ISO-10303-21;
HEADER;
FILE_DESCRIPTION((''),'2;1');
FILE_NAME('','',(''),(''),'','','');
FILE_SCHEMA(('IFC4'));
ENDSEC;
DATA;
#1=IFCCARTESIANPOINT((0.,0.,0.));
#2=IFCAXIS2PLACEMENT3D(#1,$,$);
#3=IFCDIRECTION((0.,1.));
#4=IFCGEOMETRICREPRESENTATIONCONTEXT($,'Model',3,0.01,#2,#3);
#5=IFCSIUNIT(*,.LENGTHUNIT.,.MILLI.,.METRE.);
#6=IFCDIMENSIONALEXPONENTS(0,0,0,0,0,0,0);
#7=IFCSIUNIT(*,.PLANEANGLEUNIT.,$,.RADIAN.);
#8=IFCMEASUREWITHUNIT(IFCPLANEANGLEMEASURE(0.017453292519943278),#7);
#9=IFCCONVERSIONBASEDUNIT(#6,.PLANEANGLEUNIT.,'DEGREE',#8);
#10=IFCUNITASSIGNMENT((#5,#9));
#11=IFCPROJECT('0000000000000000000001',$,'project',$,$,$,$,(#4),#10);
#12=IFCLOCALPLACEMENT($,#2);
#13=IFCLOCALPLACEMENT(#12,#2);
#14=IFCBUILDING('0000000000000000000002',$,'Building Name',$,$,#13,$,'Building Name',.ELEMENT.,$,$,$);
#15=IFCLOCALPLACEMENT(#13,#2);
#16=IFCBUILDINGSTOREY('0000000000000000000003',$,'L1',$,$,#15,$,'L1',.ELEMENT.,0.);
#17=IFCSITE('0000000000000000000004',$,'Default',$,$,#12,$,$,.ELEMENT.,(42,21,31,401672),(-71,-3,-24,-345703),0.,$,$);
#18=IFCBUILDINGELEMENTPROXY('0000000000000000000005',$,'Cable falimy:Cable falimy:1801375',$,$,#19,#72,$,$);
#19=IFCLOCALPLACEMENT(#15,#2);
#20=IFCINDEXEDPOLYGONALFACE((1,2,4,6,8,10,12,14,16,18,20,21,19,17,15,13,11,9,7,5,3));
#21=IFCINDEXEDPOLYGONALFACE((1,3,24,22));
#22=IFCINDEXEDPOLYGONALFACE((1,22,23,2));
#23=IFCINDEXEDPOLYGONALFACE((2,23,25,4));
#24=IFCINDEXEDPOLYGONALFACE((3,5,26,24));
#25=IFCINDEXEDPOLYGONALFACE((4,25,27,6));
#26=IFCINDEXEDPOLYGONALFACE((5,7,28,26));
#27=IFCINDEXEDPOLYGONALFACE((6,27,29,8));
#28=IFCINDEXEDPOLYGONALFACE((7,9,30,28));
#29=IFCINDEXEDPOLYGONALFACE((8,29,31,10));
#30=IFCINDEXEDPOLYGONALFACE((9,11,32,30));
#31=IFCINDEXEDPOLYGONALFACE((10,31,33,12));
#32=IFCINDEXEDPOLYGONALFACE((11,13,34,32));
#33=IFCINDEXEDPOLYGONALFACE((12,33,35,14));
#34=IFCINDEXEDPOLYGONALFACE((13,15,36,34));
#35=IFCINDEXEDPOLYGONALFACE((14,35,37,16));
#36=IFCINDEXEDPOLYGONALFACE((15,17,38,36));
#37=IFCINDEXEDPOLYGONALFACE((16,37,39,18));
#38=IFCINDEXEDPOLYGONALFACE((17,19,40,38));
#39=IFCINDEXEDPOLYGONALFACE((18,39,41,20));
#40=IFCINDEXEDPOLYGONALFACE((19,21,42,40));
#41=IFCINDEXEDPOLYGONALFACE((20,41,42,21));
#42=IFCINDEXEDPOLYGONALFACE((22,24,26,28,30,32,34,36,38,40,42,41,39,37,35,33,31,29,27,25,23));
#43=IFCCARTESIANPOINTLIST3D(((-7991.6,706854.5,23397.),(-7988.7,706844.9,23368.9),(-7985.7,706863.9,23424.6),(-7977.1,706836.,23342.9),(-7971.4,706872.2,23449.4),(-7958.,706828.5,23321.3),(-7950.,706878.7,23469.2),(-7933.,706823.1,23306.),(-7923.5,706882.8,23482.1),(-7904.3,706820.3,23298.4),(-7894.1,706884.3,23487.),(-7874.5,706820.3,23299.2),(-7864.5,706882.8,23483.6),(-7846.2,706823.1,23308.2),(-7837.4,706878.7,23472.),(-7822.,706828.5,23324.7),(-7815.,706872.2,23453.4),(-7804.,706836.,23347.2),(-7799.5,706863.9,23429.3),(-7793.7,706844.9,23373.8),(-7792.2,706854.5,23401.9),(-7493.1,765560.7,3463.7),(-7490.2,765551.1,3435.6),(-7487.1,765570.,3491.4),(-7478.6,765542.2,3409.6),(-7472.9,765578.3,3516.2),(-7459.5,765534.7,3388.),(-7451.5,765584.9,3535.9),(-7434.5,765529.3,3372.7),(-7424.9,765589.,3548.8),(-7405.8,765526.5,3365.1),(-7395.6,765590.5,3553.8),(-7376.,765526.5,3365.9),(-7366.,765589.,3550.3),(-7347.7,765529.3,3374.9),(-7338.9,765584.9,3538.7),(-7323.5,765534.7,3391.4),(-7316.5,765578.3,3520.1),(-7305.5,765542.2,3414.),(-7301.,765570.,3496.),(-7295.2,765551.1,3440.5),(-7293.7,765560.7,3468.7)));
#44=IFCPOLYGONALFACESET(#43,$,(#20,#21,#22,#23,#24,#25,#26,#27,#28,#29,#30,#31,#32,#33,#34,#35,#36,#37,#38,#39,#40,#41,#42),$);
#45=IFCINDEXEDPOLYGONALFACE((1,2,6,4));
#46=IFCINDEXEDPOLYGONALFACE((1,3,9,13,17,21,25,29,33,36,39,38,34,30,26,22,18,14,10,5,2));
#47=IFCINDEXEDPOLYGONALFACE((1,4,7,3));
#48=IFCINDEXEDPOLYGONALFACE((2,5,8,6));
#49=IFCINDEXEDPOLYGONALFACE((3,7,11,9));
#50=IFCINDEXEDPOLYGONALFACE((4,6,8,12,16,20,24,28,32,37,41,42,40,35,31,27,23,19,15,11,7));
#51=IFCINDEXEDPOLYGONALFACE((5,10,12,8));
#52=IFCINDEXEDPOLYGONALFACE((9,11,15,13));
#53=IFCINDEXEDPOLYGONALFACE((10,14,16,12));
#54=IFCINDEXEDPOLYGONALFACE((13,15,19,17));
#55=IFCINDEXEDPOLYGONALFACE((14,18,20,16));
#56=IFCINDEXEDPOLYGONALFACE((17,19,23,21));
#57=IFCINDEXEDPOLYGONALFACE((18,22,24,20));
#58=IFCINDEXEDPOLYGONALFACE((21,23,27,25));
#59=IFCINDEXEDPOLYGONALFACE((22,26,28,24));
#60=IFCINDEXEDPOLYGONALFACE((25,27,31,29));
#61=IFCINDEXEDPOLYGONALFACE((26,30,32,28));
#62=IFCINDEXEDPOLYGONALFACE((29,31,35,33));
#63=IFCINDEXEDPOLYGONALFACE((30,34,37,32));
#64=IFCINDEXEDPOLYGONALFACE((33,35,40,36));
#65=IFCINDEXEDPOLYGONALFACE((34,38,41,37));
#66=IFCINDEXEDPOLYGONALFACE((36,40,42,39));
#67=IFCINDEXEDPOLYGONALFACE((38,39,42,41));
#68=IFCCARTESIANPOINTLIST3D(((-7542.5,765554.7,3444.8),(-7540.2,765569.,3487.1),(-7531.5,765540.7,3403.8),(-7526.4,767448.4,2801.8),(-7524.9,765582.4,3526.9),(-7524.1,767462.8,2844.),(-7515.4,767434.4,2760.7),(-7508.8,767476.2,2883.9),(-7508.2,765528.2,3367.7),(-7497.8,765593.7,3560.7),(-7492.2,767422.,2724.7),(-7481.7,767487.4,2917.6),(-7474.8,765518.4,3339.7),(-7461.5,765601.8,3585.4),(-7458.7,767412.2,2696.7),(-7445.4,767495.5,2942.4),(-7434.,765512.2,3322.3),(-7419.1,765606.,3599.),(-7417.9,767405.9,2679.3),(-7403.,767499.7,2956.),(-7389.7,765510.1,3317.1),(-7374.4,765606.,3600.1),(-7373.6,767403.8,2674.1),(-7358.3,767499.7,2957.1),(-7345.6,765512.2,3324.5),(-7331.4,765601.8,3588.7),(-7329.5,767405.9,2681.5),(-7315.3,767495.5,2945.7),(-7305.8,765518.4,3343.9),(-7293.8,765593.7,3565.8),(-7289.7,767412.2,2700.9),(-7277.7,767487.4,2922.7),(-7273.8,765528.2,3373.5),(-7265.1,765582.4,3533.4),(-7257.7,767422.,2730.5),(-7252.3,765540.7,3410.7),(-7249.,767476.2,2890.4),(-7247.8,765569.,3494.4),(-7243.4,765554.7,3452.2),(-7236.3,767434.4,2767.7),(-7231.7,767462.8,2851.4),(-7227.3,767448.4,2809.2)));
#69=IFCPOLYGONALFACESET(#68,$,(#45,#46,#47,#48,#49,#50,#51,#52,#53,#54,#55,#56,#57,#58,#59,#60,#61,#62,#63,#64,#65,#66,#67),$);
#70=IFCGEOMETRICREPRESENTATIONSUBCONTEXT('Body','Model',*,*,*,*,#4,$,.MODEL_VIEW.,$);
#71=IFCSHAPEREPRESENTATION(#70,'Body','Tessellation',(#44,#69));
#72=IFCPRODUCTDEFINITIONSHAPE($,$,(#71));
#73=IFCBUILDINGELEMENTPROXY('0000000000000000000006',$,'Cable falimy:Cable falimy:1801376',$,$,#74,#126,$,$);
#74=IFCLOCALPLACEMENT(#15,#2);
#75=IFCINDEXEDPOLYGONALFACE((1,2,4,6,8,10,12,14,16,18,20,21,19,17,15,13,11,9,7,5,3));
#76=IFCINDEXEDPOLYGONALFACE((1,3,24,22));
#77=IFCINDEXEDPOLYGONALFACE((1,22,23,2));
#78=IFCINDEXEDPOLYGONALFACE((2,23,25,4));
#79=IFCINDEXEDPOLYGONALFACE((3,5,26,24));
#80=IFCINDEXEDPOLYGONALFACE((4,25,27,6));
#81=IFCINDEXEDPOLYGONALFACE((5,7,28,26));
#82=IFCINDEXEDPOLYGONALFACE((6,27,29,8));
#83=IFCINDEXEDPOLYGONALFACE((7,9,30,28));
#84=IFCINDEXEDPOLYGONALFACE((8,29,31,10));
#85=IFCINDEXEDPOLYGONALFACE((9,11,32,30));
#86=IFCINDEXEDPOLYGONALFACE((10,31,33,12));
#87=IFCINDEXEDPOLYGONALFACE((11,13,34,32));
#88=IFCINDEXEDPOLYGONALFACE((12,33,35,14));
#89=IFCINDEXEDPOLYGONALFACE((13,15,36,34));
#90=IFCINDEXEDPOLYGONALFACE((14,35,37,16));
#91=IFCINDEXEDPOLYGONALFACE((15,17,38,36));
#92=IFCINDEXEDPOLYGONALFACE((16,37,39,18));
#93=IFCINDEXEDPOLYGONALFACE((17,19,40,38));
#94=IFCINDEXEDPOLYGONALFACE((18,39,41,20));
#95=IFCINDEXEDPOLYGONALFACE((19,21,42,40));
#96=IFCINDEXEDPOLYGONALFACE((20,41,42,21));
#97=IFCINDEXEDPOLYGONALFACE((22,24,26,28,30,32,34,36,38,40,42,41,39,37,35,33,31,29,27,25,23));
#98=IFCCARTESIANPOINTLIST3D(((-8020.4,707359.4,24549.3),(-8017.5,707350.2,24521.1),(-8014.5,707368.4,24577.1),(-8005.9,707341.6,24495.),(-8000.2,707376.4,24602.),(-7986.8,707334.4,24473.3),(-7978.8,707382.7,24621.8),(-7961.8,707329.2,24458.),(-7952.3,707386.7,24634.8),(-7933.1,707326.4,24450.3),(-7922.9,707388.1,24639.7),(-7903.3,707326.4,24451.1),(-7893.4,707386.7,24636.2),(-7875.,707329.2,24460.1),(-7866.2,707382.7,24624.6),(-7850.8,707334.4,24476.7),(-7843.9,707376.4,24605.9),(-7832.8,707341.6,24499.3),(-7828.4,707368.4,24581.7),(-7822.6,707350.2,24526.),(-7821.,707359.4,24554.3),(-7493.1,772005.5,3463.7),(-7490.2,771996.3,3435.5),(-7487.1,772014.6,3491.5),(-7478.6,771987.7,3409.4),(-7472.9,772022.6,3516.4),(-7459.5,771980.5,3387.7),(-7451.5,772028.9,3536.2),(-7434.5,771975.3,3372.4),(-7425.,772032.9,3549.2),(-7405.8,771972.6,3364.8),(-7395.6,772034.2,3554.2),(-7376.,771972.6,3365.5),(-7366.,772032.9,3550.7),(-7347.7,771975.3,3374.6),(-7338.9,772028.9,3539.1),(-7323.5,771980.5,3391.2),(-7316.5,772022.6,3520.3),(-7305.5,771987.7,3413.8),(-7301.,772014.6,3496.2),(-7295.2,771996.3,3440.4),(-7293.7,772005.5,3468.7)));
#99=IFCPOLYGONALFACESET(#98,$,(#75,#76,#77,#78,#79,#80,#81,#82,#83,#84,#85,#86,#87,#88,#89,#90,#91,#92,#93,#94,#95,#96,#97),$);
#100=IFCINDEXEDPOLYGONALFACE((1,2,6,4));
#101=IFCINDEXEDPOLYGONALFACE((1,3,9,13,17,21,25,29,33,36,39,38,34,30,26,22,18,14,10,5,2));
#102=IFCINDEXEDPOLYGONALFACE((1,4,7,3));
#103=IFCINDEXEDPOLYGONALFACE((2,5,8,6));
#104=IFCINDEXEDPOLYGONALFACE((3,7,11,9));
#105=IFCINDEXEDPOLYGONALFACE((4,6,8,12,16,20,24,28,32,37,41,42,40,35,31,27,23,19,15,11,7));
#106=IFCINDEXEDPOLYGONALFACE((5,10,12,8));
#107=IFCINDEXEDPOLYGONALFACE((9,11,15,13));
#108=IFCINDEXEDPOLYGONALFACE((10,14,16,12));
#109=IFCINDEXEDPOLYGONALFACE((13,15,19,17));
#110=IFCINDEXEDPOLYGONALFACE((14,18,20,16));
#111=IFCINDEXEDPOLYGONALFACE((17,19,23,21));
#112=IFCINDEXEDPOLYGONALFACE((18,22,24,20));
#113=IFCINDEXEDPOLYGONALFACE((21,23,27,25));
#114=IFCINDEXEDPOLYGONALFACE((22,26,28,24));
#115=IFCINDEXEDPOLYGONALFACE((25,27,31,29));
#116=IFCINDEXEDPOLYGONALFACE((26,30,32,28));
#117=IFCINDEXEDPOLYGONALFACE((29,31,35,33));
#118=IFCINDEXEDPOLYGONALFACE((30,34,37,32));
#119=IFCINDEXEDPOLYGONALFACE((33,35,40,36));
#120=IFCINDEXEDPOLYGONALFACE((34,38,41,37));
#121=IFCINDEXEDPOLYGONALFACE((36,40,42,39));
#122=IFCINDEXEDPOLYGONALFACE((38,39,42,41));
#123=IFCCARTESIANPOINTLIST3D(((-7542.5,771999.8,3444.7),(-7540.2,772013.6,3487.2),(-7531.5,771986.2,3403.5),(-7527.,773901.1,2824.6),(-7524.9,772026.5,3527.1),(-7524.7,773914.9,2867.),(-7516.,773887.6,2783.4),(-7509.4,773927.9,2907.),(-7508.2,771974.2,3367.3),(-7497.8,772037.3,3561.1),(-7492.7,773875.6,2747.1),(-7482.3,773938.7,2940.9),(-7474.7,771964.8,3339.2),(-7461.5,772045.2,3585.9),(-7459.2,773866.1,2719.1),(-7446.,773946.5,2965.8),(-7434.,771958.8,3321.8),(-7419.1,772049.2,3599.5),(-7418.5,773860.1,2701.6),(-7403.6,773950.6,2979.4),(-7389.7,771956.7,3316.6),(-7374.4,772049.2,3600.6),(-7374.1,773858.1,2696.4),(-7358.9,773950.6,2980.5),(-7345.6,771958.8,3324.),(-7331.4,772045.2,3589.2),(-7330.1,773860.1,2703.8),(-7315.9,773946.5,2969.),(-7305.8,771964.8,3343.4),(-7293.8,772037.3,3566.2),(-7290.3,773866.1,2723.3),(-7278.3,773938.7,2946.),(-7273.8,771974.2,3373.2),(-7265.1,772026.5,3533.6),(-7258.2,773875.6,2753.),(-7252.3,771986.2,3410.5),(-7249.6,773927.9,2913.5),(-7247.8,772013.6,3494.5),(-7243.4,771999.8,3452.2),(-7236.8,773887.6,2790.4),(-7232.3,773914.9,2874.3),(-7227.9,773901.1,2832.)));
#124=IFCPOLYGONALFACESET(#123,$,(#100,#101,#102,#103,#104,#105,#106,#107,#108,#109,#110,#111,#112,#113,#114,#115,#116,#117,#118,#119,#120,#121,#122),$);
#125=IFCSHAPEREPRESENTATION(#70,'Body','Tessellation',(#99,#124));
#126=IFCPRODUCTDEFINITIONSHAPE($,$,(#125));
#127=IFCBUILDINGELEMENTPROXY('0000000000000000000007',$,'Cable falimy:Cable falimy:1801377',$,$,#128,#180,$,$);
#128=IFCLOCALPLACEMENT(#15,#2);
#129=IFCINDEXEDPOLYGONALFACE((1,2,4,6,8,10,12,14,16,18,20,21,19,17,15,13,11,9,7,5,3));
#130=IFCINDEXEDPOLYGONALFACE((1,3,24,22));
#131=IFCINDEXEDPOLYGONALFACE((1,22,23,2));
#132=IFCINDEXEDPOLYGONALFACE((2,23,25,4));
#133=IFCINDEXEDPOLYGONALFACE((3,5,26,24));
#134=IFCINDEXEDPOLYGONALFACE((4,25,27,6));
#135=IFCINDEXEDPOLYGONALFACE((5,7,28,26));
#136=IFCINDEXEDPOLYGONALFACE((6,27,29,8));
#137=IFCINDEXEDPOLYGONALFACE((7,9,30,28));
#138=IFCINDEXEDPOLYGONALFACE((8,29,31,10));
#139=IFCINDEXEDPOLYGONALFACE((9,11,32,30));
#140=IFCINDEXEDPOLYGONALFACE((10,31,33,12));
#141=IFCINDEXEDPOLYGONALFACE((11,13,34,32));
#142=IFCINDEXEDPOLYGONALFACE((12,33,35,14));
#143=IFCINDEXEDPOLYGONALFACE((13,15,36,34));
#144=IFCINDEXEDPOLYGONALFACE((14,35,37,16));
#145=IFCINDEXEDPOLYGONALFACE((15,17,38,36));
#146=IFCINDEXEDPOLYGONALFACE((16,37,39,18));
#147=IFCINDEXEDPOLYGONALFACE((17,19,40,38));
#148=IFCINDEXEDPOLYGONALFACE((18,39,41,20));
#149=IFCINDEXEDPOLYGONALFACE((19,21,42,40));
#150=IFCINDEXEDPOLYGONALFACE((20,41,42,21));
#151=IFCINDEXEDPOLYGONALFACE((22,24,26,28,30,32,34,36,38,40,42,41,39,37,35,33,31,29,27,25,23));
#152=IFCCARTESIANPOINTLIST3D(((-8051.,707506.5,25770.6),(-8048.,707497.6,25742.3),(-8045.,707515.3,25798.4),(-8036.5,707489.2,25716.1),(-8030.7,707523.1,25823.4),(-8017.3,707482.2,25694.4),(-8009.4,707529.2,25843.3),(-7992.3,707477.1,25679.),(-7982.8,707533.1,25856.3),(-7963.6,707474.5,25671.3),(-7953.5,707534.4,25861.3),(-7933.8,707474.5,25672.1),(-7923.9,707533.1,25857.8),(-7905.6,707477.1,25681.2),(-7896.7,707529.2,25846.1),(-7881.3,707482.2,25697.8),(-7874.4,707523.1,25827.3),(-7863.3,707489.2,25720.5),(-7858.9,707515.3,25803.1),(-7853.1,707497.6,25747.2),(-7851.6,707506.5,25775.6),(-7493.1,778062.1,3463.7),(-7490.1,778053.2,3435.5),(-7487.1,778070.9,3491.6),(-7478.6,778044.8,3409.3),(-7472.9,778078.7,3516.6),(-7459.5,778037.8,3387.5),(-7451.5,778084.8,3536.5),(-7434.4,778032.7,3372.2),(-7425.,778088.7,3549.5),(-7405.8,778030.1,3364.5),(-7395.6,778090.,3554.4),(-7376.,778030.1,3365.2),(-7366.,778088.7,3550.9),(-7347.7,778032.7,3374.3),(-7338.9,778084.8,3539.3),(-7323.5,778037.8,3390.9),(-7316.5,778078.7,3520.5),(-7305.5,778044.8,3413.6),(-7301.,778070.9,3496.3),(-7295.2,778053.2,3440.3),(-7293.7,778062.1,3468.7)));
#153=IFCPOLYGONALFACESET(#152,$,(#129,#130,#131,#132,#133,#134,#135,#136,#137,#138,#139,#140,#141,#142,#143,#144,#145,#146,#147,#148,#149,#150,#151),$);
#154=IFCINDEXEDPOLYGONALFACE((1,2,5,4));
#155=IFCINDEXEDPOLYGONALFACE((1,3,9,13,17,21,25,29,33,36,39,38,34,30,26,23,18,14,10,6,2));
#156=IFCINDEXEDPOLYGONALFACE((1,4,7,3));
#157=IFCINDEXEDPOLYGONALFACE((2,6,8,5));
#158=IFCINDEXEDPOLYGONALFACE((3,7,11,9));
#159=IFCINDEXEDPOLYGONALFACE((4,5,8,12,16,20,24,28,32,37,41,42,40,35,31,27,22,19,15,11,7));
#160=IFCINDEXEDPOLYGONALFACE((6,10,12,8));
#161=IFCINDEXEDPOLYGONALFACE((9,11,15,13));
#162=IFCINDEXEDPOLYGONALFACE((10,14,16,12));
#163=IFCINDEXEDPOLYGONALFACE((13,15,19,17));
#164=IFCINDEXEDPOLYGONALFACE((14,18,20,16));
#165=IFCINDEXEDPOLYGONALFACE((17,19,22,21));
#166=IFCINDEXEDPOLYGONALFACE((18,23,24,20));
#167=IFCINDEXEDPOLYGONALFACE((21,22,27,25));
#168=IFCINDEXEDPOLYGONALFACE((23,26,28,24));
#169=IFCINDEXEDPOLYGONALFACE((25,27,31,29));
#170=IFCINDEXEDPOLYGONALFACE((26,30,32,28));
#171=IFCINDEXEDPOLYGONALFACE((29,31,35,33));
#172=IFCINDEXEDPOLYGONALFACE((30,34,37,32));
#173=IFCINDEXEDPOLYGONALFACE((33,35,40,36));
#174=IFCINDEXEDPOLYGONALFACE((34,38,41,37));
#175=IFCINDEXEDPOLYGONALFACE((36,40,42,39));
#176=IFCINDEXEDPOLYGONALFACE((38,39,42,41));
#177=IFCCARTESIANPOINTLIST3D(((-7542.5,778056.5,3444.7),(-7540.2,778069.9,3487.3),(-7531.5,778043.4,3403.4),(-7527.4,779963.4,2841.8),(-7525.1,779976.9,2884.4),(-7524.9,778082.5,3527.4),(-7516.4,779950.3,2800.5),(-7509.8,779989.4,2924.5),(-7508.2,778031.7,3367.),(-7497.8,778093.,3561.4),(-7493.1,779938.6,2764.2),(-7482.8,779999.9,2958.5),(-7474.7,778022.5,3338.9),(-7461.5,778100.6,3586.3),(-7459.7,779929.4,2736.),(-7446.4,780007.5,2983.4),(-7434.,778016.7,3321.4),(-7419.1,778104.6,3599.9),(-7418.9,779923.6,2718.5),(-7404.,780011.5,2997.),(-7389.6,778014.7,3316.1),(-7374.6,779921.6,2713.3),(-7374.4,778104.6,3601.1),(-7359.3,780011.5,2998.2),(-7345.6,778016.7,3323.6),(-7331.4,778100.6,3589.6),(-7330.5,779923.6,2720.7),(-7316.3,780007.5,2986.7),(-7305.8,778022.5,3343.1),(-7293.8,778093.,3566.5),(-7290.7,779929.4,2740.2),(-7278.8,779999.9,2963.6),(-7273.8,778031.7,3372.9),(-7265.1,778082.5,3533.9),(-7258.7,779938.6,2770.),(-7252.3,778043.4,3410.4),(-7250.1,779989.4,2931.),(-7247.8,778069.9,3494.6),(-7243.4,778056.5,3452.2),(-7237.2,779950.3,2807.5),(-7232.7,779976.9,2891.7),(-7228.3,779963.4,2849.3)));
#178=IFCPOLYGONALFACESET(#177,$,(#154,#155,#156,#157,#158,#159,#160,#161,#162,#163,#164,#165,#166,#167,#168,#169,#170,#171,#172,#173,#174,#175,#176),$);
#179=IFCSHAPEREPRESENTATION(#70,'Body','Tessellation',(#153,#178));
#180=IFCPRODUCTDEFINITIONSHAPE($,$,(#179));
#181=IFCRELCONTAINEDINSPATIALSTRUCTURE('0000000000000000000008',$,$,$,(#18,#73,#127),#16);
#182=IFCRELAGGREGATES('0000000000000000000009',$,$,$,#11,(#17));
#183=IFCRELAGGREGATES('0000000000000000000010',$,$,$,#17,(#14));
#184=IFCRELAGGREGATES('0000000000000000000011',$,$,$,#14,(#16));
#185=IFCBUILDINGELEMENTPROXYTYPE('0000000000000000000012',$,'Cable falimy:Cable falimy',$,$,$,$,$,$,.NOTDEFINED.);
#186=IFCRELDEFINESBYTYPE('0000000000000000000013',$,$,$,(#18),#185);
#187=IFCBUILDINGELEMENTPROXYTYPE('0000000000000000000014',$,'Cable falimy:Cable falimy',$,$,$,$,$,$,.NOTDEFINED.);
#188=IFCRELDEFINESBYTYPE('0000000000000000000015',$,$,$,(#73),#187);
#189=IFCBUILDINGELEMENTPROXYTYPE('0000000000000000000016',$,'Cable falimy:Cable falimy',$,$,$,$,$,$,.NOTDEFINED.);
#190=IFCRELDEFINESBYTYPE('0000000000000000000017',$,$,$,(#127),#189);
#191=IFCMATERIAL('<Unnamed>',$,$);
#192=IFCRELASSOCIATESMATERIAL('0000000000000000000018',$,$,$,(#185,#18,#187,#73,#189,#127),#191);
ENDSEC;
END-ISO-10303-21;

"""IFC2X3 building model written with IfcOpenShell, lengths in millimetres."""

from ifc_helpers import new_model, entity, si_unit, converted_unit, direction, frame, frame_2d, origin, place, context, subcontext, project, spatial, circle, extrude, source, transform, mapped, material, type_object, type_shapes, element, save


model = new_model("IFC2X3")

# Units and contexts
model_context = context("Model", 3, precision=0.01, world=origin(), true_north=direction((0.0, 1.0)))
body_context = subcontext(model_context, "Body", "Model", "MODEL_VIEW")
ifc_project = project(units=[si_unit("LENGTHUNIT", "METRE", prefix="MILLI"), converted_unit("PLANEANGLEUNIT", "DEGREE", entity("IfcPlaneAngleMeasure", 0.017453292519943278), si_unit("PLANEANGLEUNIT", "RADIAN"), dimensions=[0, 0, 0, 0, 0, 0, 0])], contexts=[model_context])

# Site, building, storey
site_placement = place(None, origin())
site = spatial("IfcSite", under=ifc_project, at=site_placement, Name="Default", CompositionType="ELEMENT", RefLatitude=(42, 21, 31, 401672), RefLongitude=(-71, -3, -24, -345703), RefElevation=0.0)
building_placement = place(site_placement, origin())
building = spatial("IfcBuilding", under=site, at=building_placement, Name="Building Name", LongName="Building Name", CompositionType="ELEMENT")
storey_placement = place(building_placement, origin())
storey = spatial("IfcBuildingStorey", under=building, at=storey_placement, Name="L1", LongName="L1", CompositionType="ELEMENT", Elevation=0.0)

# Shared definitions
ifc_material = material(Name="<Unnamed>")

# Building element proxies
building_element_proxy_type_1 = type_object("IfcBuildingElementProxyType", Name="Cable falimy:Cable falimy", PredefinedType="NOTDEFINED", material=ifc_material)
shared_shape_1 = source(origin(), body_context, "Body", "SweptSolid", [
    extrude(circle(Radius=100.0, at=frame_2d((0.0, 0.0), x_axis=(1.0, 0.0))), frame((0.0, 0.0, 0.0), z_axis=(0.946874, 0.0, 0.321605), x_axis=(-0.321605, 0.0, 0.946874)), (0.0, 0.0, 1.0), 62000.0),
    extrude(circle(Radius=150.0, at=frame_2d((0.0, 0.0), x_axis=(1.0, 0.0))), frame((-1893.7, 0.0, -643.2), z_axis=(0.946874, 0.0, 0.321605), x_axis=(0.321605, 0.0, -0.946874)), (0.0, 0.0, 1.0), 2000.0),
])
type_shapes(building_element_proxy_type_1, [shared_shape_1])
proxy_1_placement = place(storey_placement, frame((-7393.2, 765558.3, 3459.1), z_axis=(-0.025001, 0.0, 0.999687), x_axis=(0.0, -1.0, 0.0)))
element("IfcBuildingElementProxy", 1, at=proxy_1_placement, inside=storey, type_object=building_element_proxy_type_1, material=ifc_material, Name="Cable falimy:Cable falimy:1801375", context=body_context, shape_type="MappedRepresentation", body=[
    mapped(shared_shape_1, transform((0.0, 0.0, 0.0), scale=1.0)),
])
building_element_proxy_type_2 = type_object("IfcBuildingElementProxyType", Name="Cable falimy:Cable falimy", PredefinedType="NOTDEFINED", material=ifc_material)
shared_shape_2 = source(origin(), body_context, "Body", "SweptSolid", [
    extrude(circle(Radius=100.0, at=frame_2d((0.0, 0.0), x_axis=(1.0, 0.0))), frame((0.0, 0.0, 0.0), z_axis=(0.950678, 0.0, 0.310179), x_axis=(-0.310179, 0.0, 0.950678)), (0.0, 0.0, 1.0), 68000.0),
    extrude(circle(Radius=150.0, at=frame_2d((0.0, 0.0), x_axis=(1.0, 0.0))), frame((-1901.4, 0.0, -620.4), z_axis=(0.950678, 0.0, 0.310179), x_axis=(0.310179, 0.0, -0.950678)), (0.0, 0.0, 1.0), 2000.0),
])
type_shapes(building_element_proxy_type_2, [shared_shape_2])
proxy_2_placement = place(storey_placement, frame((-7393.2, 772003.2, 3459.1), z_axis=(-0.025001, 0.0, 0.999687), x_axis=(0.0, -1.0, 0.0)))
element("IfcBuildingElementProxy", 2, at=proxy_2_placement, inside=storey, type_object=building_element_proxy_type_2, material=ifc_material, Name="Cable falimy:Cable falimy:1801376", context=body_context, shape_type="MappedRepresentation", body=[
    mapped(shared_shape_2, transform((0.0, 0.0, 0.0), scale=1.0)),
])
building_element_proxy_type_3 = type_object("IfcBuildingElementProxyType", Name="Cable falimy:Cable falimy", PredefinedType="NOTDEFINED", material=ifc_material)
shared_shape_3 = source(origin(), body_context, "Body", "SweptSolid", [
    extrude(circle(Radius=100.0, at=frame_2d((0.0, 0.0), x_axis=(1.0, 0.0))), frame((0.0, 0.0, 0.0), z_axis=(0.953454, 0.0, 0.301538), x_axis=(-0.301538, 0.0, 0.953454)), (0.0, 0.0, 1.0), 74000.0),
    extrude(circle(Radius=150.0, at=frame_2d((0.0, 0.0), x_axis=(1.0, 0.0))), frame((-1906.9, 0.0, -603.1), z_axis=(0.953454, 0.0, 0.301538), x_axis=(0.301538, 0.0, -0.953454)), (0.0, 0.0, 1.0), 2000.0),
])
type_shapes(building_element_proxy_type_3, [shared_shape_3])
proxy_3_placement = place(storey_placement, frame((-7393.2, 778059.9, 3459.1), z_axis=(-0.025001, 0.0, 0.999687), x_axis=(0.0, -1.0, 0.0)))
element("IfcBuildingElementProxy", 3, at=proxy_3_placement, inside=storey, type_object=building_element_proxy_type_3, material=ifc_material, Name="Cable falimy:Cable falimy:1801377", context=body_context, shape_type="MappedRepresentation", body=[
    mapped(shared_shape_3, transform((0.0, 0.0, 0.0), scale=1.0)),
])

save(model, "model.ifc")
